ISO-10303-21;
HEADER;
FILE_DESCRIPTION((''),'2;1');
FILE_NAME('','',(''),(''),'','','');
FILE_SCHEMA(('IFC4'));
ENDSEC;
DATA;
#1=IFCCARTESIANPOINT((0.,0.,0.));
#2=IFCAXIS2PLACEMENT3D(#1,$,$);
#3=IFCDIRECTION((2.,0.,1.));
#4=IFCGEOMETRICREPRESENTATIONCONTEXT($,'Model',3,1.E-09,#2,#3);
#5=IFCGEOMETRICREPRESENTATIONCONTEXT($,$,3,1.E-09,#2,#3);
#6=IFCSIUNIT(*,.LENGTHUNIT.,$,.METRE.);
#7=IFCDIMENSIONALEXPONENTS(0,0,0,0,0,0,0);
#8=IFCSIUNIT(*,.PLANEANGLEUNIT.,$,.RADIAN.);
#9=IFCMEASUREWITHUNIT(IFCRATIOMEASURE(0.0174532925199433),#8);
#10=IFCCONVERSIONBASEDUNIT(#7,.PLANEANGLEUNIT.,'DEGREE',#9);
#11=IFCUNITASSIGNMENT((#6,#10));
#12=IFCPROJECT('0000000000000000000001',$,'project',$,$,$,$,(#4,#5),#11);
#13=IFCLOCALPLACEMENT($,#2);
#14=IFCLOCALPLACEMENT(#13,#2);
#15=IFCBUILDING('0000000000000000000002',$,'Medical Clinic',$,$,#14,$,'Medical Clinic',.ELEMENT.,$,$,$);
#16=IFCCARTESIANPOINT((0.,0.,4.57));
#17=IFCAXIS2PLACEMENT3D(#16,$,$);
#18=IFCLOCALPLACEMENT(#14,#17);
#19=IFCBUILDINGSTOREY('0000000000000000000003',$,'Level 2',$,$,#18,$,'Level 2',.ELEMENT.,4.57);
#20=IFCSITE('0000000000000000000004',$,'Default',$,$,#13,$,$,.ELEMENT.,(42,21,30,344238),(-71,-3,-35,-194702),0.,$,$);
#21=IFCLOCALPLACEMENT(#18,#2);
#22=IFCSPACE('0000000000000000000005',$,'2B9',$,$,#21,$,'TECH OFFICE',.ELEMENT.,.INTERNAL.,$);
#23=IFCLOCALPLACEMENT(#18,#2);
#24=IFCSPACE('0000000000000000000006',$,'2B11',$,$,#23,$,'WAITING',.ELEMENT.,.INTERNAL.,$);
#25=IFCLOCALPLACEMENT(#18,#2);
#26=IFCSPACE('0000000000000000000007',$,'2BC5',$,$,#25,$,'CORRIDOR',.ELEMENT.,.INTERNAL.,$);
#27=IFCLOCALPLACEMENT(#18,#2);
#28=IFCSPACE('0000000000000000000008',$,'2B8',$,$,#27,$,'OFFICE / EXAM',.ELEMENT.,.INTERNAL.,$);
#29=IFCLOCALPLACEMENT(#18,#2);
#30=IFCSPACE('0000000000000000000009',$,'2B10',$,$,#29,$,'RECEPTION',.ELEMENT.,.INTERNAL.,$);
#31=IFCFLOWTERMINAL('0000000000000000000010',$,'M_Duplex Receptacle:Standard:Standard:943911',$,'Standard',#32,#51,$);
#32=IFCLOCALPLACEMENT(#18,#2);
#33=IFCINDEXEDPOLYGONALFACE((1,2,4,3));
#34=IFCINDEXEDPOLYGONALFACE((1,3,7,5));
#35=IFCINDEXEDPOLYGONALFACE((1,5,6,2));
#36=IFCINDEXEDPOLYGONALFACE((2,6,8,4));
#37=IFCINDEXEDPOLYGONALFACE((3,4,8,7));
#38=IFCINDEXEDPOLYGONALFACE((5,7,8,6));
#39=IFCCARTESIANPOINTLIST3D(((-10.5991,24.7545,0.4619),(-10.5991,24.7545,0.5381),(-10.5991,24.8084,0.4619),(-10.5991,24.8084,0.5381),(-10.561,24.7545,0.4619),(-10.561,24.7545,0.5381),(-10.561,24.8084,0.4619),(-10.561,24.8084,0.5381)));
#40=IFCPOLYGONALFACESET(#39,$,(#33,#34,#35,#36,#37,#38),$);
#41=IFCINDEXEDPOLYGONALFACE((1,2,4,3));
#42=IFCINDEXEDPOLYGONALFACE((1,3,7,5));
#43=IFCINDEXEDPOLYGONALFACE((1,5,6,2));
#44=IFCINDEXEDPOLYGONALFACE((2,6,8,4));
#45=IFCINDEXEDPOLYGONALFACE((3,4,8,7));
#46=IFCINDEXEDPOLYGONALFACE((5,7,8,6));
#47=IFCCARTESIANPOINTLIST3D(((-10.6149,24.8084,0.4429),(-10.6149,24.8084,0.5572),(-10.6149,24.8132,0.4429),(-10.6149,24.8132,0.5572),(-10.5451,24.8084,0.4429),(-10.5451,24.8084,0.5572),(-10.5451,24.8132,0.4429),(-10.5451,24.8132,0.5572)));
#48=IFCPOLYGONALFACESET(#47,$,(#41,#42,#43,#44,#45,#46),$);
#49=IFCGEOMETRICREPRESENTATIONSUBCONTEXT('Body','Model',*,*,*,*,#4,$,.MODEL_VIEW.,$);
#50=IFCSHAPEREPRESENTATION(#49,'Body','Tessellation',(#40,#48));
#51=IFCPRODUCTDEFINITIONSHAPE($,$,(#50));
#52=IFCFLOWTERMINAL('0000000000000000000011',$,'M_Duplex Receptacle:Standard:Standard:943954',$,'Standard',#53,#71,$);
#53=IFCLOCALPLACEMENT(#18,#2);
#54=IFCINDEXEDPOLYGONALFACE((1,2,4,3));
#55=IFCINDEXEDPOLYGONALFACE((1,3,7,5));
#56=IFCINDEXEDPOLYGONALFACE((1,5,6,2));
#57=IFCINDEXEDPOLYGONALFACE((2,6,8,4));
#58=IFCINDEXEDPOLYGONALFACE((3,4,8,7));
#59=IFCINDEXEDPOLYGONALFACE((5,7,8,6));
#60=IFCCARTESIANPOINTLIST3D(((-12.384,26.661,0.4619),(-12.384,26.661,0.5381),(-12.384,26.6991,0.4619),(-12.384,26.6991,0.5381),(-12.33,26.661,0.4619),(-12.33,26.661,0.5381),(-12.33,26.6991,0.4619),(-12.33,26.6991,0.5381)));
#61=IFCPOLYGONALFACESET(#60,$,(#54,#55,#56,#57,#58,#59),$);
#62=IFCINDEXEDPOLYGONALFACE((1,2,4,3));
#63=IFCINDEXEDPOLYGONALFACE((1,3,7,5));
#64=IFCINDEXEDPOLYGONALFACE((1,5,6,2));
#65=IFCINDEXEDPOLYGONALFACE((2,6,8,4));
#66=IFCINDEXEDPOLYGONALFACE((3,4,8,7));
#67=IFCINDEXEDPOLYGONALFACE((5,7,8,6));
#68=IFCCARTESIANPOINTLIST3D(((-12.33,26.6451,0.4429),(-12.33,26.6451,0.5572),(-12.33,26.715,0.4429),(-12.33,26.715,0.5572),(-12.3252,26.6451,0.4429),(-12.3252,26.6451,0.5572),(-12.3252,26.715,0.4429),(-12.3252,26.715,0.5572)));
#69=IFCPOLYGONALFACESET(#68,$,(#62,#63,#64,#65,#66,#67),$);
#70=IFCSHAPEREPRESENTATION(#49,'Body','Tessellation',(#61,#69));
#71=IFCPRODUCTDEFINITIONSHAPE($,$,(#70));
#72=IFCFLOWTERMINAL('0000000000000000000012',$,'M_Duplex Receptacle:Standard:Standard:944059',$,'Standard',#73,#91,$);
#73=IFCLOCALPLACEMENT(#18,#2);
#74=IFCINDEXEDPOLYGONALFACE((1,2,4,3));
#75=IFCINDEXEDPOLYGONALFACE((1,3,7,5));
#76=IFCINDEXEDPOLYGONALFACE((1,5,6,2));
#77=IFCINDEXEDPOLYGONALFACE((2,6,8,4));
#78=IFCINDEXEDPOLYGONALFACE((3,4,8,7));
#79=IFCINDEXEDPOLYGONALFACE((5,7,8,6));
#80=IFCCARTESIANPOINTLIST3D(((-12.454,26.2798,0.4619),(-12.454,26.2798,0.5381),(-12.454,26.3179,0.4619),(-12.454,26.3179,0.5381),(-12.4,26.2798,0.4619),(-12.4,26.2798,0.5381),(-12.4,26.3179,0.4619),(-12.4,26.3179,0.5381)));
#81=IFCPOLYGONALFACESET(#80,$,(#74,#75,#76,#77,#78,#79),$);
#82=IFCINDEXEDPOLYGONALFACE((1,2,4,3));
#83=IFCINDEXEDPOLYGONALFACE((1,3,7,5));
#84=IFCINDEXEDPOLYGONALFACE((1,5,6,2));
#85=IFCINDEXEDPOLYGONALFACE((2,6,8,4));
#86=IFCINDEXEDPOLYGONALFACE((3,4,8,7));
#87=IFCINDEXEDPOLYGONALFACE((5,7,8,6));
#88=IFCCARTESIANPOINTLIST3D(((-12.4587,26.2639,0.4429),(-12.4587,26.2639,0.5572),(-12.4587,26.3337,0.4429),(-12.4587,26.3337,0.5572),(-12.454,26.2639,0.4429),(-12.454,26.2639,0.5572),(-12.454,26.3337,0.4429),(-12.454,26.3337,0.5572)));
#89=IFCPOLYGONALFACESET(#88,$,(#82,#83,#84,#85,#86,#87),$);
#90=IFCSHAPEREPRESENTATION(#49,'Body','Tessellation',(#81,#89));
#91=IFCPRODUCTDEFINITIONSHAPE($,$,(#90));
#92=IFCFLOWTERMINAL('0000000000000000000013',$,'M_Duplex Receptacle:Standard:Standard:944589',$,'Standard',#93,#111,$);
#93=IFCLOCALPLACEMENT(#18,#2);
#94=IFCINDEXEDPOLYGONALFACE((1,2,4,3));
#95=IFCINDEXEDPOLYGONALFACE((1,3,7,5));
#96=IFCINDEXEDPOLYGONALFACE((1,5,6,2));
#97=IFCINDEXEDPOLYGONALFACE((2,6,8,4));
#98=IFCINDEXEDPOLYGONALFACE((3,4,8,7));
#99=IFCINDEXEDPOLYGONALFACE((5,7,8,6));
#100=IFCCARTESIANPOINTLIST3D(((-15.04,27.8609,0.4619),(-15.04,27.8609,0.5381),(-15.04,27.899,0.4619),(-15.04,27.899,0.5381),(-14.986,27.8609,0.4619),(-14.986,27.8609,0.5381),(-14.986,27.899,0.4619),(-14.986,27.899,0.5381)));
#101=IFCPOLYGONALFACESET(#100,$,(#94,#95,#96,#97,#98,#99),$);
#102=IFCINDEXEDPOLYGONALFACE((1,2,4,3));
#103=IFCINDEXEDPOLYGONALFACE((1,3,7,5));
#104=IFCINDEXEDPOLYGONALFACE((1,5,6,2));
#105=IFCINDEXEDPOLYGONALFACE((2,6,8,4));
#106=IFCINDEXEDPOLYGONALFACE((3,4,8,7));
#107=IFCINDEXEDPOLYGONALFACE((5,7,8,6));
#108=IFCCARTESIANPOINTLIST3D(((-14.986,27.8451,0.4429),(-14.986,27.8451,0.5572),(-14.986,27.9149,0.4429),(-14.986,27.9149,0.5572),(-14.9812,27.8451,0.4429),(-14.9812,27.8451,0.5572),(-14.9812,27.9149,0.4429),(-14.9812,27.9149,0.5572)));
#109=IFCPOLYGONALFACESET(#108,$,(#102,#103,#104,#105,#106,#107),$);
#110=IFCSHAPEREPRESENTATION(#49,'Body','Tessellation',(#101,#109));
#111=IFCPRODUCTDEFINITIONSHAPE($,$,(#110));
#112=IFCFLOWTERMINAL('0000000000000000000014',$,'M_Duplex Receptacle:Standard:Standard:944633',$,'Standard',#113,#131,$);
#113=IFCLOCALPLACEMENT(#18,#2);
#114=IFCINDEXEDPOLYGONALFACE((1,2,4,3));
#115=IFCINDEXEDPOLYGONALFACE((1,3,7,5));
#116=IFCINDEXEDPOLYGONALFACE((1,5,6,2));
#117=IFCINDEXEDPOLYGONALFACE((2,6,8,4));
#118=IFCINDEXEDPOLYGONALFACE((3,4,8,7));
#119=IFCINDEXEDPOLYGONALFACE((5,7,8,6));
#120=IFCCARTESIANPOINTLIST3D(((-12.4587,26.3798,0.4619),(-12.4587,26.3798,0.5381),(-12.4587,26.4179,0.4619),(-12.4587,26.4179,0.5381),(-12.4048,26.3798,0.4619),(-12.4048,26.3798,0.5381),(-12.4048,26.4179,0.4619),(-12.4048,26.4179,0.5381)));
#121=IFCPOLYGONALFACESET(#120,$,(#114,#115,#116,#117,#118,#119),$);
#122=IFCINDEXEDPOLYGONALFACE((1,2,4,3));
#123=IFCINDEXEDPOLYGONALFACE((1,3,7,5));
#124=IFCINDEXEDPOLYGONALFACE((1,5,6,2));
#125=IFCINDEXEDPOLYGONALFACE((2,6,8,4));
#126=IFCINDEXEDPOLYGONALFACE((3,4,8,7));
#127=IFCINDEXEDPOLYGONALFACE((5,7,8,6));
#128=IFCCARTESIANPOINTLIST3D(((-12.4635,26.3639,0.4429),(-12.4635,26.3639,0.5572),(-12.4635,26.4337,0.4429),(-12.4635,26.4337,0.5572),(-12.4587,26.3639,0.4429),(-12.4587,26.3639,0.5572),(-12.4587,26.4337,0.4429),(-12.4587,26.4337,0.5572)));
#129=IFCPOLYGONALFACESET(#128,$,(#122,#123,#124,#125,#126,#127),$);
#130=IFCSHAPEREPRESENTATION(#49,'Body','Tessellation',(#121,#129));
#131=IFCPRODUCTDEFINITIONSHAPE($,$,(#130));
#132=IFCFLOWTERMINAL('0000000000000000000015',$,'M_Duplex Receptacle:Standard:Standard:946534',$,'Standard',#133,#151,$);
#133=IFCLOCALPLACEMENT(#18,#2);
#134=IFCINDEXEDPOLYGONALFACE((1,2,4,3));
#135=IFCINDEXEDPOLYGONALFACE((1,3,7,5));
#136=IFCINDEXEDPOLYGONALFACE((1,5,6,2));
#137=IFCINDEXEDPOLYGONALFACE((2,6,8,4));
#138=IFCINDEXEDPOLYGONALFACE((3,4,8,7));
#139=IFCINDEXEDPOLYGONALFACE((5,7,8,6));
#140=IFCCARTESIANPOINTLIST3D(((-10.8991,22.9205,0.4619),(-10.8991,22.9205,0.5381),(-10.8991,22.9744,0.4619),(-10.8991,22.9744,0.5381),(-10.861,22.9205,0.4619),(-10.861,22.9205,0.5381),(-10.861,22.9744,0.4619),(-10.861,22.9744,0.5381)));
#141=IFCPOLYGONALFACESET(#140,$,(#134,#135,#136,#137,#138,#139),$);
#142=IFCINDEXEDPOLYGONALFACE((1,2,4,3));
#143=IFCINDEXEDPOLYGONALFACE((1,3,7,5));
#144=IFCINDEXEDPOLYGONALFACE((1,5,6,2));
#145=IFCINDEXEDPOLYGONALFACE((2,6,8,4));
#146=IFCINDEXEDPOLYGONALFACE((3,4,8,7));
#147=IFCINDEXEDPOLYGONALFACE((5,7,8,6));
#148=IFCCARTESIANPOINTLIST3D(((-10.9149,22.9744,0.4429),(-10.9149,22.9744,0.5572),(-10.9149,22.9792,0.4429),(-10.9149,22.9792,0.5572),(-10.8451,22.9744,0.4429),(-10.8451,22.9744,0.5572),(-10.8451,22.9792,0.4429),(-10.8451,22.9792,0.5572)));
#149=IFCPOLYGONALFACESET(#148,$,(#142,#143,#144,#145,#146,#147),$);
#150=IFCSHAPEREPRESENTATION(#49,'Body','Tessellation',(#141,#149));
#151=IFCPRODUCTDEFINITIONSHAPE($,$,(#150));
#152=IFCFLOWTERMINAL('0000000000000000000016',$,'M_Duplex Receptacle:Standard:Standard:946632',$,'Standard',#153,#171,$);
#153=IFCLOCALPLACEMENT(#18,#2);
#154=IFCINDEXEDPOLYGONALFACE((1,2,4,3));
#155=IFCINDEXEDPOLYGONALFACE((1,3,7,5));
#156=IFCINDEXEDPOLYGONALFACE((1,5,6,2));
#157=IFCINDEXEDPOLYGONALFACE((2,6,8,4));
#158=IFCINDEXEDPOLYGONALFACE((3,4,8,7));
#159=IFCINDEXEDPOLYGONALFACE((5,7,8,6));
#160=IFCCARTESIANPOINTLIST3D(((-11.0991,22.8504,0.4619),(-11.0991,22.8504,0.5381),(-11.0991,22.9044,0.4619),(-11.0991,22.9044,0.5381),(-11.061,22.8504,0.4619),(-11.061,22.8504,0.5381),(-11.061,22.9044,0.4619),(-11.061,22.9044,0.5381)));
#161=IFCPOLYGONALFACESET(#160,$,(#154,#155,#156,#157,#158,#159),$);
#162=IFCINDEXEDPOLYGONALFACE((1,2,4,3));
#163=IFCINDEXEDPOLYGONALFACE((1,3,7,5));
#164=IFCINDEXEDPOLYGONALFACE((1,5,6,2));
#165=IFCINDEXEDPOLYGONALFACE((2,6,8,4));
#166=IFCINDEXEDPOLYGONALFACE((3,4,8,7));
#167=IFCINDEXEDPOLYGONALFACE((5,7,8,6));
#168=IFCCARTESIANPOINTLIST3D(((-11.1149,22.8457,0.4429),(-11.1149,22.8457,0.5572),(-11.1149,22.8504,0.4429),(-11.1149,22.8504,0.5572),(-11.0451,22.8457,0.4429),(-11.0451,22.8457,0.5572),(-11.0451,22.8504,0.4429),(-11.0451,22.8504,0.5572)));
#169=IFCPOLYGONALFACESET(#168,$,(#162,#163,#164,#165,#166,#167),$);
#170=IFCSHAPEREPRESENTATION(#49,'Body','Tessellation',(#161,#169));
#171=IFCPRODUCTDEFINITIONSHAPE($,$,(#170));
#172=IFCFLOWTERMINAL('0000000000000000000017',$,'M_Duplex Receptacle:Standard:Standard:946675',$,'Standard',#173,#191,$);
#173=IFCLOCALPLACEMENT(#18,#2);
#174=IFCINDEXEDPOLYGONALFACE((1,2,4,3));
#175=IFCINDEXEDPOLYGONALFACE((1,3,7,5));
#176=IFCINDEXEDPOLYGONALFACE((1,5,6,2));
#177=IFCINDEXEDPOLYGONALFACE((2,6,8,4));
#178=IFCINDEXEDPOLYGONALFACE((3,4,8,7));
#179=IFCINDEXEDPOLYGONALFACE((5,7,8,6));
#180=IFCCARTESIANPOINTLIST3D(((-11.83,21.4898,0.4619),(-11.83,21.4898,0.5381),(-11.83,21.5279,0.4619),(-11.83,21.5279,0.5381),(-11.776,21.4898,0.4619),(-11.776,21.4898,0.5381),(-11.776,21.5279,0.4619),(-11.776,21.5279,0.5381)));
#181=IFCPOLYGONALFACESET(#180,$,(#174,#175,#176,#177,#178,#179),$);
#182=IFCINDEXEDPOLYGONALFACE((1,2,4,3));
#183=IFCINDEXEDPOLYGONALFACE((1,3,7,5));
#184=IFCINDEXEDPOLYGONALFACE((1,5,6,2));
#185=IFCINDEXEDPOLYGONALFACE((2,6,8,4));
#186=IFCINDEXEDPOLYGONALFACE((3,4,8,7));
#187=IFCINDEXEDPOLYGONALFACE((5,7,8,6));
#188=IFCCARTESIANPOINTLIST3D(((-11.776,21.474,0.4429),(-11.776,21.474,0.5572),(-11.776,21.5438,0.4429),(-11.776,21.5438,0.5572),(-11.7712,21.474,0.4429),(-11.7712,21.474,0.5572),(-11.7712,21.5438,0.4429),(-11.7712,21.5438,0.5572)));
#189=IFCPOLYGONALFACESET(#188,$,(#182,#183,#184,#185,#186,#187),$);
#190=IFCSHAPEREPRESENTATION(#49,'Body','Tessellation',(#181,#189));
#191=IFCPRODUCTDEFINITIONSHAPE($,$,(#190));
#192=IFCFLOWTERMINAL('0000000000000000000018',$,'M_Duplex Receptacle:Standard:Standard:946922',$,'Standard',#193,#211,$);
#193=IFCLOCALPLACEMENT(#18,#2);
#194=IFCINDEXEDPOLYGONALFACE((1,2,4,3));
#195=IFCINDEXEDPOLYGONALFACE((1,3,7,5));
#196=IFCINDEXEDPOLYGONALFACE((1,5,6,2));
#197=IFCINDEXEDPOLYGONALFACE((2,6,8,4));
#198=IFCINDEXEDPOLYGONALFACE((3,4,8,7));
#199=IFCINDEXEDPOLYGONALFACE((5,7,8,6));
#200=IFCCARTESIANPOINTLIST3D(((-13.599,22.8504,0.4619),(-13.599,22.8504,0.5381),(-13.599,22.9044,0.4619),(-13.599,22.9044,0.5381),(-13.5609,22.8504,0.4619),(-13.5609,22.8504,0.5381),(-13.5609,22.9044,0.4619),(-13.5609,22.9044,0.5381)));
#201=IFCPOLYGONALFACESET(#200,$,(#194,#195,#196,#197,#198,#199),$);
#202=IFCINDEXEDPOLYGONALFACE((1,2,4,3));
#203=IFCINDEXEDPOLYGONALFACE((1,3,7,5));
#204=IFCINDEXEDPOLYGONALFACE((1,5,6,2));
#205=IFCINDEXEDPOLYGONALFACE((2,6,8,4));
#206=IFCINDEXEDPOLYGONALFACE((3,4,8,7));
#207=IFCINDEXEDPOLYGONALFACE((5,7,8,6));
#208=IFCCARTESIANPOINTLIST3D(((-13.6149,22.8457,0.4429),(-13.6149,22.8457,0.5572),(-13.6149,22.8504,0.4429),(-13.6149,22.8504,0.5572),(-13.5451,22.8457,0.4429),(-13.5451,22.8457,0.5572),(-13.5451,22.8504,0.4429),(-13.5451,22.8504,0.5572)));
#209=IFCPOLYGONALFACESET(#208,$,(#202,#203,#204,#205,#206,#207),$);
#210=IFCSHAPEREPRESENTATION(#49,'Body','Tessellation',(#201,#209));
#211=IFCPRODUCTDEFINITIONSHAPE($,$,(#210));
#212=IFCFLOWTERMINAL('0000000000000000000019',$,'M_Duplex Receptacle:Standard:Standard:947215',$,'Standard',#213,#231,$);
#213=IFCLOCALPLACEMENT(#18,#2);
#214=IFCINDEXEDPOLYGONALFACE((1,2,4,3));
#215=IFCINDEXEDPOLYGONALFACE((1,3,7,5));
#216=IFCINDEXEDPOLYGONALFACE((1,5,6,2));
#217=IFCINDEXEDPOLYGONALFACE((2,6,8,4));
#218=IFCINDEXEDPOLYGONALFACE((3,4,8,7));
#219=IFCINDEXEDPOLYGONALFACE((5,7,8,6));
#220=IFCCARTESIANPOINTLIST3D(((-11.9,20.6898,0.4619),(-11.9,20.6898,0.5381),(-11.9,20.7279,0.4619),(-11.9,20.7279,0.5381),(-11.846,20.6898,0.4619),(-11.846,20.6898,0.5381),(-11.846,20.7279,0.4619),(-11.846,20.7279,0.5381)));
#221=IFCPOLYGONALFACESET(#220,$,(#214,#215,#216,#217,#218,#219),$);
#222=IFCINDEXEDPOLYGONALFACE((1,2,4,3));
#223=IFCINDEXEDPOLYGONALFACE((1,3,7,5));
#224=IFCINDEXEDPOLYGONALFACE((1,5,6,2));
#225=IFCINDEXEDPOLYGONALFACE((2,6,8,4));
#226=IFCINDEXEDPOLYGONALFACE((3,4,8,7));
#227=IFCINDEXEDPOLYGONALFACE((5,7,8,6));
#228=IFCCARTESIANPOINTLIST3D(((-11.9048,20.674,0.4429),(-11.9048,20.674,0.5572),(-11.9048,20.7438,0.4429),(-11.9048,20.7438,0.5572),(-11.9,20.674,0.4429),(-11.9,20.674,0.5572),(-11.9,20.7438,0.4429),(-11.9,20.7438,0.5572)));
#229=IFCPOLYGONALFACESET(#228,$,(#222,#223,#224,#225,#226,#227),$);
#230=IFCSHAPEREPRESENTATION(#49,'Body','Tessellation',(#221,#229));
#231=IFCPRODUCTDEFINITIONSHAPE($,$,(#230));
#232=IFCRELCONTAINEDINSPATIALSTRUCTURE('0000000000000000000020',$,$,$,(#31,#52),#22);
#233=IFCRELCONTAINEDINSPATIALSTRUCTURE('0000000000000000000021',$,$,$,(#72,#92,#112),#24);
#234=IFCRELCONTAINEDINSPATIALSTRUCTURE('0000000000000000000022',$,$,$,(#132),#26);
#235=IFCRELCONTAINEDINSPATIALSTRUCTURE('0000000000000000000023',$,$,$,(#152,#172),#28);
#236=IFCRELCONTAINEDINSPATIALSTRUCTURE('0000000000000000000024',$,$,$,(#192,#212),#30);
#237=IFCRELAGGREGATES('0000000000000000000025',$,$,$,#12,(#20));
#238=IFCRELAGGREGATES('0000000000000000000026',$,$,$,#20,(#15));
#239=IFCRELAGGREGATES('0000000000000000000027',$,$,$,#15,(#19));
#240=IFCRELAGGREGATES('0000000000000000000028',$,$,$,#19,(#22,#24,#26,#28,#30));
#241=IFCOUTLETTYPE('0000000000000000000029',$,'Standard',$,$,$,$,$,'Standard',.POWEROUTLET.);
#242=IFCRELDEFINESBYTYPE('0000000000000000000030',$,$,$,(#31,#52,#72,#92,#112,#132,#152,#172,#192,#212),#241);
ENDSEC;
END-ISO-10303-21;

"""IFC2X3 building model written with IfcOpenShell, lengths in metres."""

from ifc_helpers import new_model, entity, si_unit, converted_unit, direction, frame, frame_2d, origin, origin_2d_with_axis, place, context, subcontext, project, spatial, rectangle, extrude, source, transform, mapped, type_object, type_shapes, element, save


model = new_model("IFC2X3")

# Units and contexts
model_context = context("Model", 3, precision=1e-09, world=origin(), true_north=direction((2.0, 0.0, 1.0)))
context_of_model = context(None, 3, precision=1e-09, world=origin(), true_north=direction((2.0, 0.0, 1.0)))
body_context = subcontext(model_context, "Body", "Model", "MODEL_VIEW")
ifc_project = project(units=[si_unit("LENGTHUNIT", "METRE"), converted_unit("PLANEANGLEUNIT", "DEGREE", entity("IfcRatioMeasure", 0.0174532925199433), si_unit("PLANEANGLEUNIT", "RADIAN"), dimensions=[0, 0, 0, 0, 0, 0, 0])], contexts=[model_context, context_of_model])

# Site, building, storey, space
site_placement = place(None, origin())
site = spatial("IfcSite", under=ifc_project, at=site_placement, Name="Default", CompositionType="ELEMENT", RefLatitude=(42, 21, 30, 344238), RefLongitude=(-71, -3, -35, -194702), RefElevation=0.0)
building_placement = place(site_placement, origin())
building = spatial("IfcBuilding", under=site, at=building_placement, Name="Medical Clinic", LongName="Medical Clinic", CompositionType="ELEMENT")
storey_placement = place(building_placement, frame((0.0, 0.0, 4.57)))
storey = spatial("IfcBuildingStorey", under=building, at=storey_placement, Name="Level 2", LongName="Level 2", CompositionType="ELEMENT", Elevation=4.57)
space_1_placement = place(storey_placement, origin())
space_1 = spatial("IfcSpace", under=storey, at=space_1_placement, Name="2B9", LongName="TECH OFFICE", CompositionType="ELEMENT", InteriorOrExteriorSpace="INTERNAL")

# Flow terminals
outlet_type = type_object("IfcOutletType", Name="Standard", ElementType="Standard", PredefinedType="POWEROUTLET")
shared_shape_1 = source(origin(), body_context, "Body", "SweptSolid", [
    extrude(rectangle(XDim=0.0381, YDim=0.0762, at=origin_2d_with_axis()), frame((0.0, 0.0, -0.054), z_axis=(0.0, 0.0, 1.0), x_axis=(-1.0, 0.0, 0.0)), (0.0, 0.0, 1.0), 0.054),
    extrude(rectangle(XDim=0.0698, YDim=0.1143, at=frame_2d((0.0, 0.0), x_axis=(1.0, 0.0))), frame((0.0, 0.0, 0.0), z_axis=(0.0, 0.0, 1.0), x_axis=(-1.0, 0.0, 0.0)), (0.0, 0.0, 1.0), 0.0048),
])
type_shapes(outlet_type, [shared_shape_1])
for number, where, z_axis, x_axis, name in (
    (1, (-10.58, 24.8084, 0.5), (0.0, 1.0, 0.0), (-1.0, 0.0, 0.0), "M_Duplex Receptacle:Standard:Standard:943911"),
    (2, (-12.33, 26.6801, 0.5), (1.0, 0.0, 0.0), (0.0, 1.0, 0.0), "M_Duplex Receptacle:Standard:Standard:943954"),
):
    element("IfcFlowTerminal", number, at=place(space_1_placement, frame(where, z_axis=z_axis, x_axis=x_axis)), inside=space_1, type_object=outlet_type, Name=name, ObjectType="Standard", context=body_context, shape_type="MappedRepresentation", body=[
        mapped(shared_shape_1, transform((0.0, 0.0, 0.0), scale=1.0)),
    ])

# Shared definitions
space_2_placement = place(storey_placement, origin())
space_2 = spatial("IfcSpace", under=storey, at=space_2_placement, Name="2B11", LongName="WAITING", CompositionType="ELEMENT", InteriorOrExteriorSpace="INTERNAL")

# Flow terminals
for number, where, z_axis, x_axis, name in (
    (3, (-12.454, 26.2988, 0.5), (-1.0, 0.0, 0.0), (0.0, -1.0, 0.0), "M_Duplex Receptacle:Standard:Standard:944059"),
    (4, (-14.986, 27.88, 0.5), (1.0, 0.0, 0.0), (0.0, 1.0, 0.0), "M_Duplex Receptacle:Standard:Standard:944589"),
    (5, (-12.4587, 26.3988, 0.5), (-1.0, 0.0, 0.0), (0.0, -1.0, 0.0), "M_Duplex Receptacle:Standard:Standard:944633"),
):
    element("IfcFlowTerminal", number, at=place(space_2_placement, frame(where, z_axis=z_axis, x_axis=x_axis)), inside=space_2, type_object=outlet_type, Name=name, ObjectType="Standard", context=body_context, shape_type="MappedRepresentation", body=[
        mapped(shared_shape_1, transform((0.0, 0.0, 0.0), scale=1.0)),
    ])

# Shared definitions
space_3_placement = place(storey_placement, origin())
space_3 = spatial("IfcSpace", under=storey, at=space_3_placement, Name="2BC5", LongName="CORRIDOR", CompositionType="ELEMENT", InteriorOrExteriorSpace="INTERNAL")

# Flow terminal
flow_terminal_1_placement = place(space_3_placement, frame((-10.88, 22.9744, 0.5), z_axis=(0.0, 1.0, 0.0), x_axis=(-1.0, 0.0, 0.0)))
element("IfcFlowTerminal", 6, at=flow_terminal_1_placement, inside=space_3, type_object=outlet_type, Name="M_Duplex Receptacle:Standard:Standard:946534", ObjectType="Standard", context=body_context, shape_type="MappedRepresentation", body=[
    mapped(shared_shape_1, transform((0.0, 0.0, 0.0), scale=1.0)),
])

# Shared definitions
space_4_placement = place(storey_placement, origin())
space_4 = spatial("IfcSpace", under=storey, at=space_4_placement, Name="2B8", LongName="OFFICE / EXAM", CompositionType="ELEMENT", InteriorOrExteriorSpace="INTERNAL")

# Flow terminals
for number, where, z_axis, x_axis, name in (
    (7, (-11.08, 22.8504, 0.5), (0.0, -1.0, 0.0), (1.0, 0.0, 0.0), "M_Duplex Receptacle:Standard:Standard:946632"),
    (8, (-11.776, 21.5089, 0.5), (1.0, 0.0, 0.0), (0.0, 1.0, 0.0), "M_Duplex Receptacle:Standard:Standard:946675"),
):
    element("IfcFlowTerminal", number, at=place(space_4_placement, frame(where, z_axis=z_axis, x_axis=x_axis)), inside=space_4, type_object=outlet_type, Name=name, ObjectType="Standard", context=body_context, shape_type="MappedRepresentation", body=[
        mapped(shared_shape_1, transform((0.0, 0.0, 0.0), scale=1.0)),
    ])

# Shared definitions
space_5_placement = place(storey_placement, origin())
space_5 = spatial("IfcSpace", under=storey, at=space_5_placement, Name="2B10", LongName="RECEPTION", CompositionType="ELEMENT", InteriorOrExteriorSpace="INTERNAL")

# Flow terminals
for number, where, z_axis, x_axis, name in (
    (9, (-13.58, 22.8504, 0.5), (0.0, -1.0, 0.0), (1.0, 0.0, 0.0), "M_Duplex Receptacle:Standard:Standard:946922"),
    (10, (-11.9, 20.7089, 0.5), (-1.0, 0.0, 0.0), (0.0, -1.0, 0.0), "M_Duplex Receptacle:Standard:Standard:947215"),
):
    element("IfcFlowTerminal", number, at=place(space_5_placement, frame(where, z_axis=z_axis, x_axis=x_axis)), inside=space_5, type_object=outlet_type, Name=name, ObjectType="Standard", context=body_context, shape_type="MappedRepresentation", body=[
        mapped(shared_shape_1, transform((0.0, 0.0, 0.0), scale=1.0)),
    ])

save(model, "model.ifc")
